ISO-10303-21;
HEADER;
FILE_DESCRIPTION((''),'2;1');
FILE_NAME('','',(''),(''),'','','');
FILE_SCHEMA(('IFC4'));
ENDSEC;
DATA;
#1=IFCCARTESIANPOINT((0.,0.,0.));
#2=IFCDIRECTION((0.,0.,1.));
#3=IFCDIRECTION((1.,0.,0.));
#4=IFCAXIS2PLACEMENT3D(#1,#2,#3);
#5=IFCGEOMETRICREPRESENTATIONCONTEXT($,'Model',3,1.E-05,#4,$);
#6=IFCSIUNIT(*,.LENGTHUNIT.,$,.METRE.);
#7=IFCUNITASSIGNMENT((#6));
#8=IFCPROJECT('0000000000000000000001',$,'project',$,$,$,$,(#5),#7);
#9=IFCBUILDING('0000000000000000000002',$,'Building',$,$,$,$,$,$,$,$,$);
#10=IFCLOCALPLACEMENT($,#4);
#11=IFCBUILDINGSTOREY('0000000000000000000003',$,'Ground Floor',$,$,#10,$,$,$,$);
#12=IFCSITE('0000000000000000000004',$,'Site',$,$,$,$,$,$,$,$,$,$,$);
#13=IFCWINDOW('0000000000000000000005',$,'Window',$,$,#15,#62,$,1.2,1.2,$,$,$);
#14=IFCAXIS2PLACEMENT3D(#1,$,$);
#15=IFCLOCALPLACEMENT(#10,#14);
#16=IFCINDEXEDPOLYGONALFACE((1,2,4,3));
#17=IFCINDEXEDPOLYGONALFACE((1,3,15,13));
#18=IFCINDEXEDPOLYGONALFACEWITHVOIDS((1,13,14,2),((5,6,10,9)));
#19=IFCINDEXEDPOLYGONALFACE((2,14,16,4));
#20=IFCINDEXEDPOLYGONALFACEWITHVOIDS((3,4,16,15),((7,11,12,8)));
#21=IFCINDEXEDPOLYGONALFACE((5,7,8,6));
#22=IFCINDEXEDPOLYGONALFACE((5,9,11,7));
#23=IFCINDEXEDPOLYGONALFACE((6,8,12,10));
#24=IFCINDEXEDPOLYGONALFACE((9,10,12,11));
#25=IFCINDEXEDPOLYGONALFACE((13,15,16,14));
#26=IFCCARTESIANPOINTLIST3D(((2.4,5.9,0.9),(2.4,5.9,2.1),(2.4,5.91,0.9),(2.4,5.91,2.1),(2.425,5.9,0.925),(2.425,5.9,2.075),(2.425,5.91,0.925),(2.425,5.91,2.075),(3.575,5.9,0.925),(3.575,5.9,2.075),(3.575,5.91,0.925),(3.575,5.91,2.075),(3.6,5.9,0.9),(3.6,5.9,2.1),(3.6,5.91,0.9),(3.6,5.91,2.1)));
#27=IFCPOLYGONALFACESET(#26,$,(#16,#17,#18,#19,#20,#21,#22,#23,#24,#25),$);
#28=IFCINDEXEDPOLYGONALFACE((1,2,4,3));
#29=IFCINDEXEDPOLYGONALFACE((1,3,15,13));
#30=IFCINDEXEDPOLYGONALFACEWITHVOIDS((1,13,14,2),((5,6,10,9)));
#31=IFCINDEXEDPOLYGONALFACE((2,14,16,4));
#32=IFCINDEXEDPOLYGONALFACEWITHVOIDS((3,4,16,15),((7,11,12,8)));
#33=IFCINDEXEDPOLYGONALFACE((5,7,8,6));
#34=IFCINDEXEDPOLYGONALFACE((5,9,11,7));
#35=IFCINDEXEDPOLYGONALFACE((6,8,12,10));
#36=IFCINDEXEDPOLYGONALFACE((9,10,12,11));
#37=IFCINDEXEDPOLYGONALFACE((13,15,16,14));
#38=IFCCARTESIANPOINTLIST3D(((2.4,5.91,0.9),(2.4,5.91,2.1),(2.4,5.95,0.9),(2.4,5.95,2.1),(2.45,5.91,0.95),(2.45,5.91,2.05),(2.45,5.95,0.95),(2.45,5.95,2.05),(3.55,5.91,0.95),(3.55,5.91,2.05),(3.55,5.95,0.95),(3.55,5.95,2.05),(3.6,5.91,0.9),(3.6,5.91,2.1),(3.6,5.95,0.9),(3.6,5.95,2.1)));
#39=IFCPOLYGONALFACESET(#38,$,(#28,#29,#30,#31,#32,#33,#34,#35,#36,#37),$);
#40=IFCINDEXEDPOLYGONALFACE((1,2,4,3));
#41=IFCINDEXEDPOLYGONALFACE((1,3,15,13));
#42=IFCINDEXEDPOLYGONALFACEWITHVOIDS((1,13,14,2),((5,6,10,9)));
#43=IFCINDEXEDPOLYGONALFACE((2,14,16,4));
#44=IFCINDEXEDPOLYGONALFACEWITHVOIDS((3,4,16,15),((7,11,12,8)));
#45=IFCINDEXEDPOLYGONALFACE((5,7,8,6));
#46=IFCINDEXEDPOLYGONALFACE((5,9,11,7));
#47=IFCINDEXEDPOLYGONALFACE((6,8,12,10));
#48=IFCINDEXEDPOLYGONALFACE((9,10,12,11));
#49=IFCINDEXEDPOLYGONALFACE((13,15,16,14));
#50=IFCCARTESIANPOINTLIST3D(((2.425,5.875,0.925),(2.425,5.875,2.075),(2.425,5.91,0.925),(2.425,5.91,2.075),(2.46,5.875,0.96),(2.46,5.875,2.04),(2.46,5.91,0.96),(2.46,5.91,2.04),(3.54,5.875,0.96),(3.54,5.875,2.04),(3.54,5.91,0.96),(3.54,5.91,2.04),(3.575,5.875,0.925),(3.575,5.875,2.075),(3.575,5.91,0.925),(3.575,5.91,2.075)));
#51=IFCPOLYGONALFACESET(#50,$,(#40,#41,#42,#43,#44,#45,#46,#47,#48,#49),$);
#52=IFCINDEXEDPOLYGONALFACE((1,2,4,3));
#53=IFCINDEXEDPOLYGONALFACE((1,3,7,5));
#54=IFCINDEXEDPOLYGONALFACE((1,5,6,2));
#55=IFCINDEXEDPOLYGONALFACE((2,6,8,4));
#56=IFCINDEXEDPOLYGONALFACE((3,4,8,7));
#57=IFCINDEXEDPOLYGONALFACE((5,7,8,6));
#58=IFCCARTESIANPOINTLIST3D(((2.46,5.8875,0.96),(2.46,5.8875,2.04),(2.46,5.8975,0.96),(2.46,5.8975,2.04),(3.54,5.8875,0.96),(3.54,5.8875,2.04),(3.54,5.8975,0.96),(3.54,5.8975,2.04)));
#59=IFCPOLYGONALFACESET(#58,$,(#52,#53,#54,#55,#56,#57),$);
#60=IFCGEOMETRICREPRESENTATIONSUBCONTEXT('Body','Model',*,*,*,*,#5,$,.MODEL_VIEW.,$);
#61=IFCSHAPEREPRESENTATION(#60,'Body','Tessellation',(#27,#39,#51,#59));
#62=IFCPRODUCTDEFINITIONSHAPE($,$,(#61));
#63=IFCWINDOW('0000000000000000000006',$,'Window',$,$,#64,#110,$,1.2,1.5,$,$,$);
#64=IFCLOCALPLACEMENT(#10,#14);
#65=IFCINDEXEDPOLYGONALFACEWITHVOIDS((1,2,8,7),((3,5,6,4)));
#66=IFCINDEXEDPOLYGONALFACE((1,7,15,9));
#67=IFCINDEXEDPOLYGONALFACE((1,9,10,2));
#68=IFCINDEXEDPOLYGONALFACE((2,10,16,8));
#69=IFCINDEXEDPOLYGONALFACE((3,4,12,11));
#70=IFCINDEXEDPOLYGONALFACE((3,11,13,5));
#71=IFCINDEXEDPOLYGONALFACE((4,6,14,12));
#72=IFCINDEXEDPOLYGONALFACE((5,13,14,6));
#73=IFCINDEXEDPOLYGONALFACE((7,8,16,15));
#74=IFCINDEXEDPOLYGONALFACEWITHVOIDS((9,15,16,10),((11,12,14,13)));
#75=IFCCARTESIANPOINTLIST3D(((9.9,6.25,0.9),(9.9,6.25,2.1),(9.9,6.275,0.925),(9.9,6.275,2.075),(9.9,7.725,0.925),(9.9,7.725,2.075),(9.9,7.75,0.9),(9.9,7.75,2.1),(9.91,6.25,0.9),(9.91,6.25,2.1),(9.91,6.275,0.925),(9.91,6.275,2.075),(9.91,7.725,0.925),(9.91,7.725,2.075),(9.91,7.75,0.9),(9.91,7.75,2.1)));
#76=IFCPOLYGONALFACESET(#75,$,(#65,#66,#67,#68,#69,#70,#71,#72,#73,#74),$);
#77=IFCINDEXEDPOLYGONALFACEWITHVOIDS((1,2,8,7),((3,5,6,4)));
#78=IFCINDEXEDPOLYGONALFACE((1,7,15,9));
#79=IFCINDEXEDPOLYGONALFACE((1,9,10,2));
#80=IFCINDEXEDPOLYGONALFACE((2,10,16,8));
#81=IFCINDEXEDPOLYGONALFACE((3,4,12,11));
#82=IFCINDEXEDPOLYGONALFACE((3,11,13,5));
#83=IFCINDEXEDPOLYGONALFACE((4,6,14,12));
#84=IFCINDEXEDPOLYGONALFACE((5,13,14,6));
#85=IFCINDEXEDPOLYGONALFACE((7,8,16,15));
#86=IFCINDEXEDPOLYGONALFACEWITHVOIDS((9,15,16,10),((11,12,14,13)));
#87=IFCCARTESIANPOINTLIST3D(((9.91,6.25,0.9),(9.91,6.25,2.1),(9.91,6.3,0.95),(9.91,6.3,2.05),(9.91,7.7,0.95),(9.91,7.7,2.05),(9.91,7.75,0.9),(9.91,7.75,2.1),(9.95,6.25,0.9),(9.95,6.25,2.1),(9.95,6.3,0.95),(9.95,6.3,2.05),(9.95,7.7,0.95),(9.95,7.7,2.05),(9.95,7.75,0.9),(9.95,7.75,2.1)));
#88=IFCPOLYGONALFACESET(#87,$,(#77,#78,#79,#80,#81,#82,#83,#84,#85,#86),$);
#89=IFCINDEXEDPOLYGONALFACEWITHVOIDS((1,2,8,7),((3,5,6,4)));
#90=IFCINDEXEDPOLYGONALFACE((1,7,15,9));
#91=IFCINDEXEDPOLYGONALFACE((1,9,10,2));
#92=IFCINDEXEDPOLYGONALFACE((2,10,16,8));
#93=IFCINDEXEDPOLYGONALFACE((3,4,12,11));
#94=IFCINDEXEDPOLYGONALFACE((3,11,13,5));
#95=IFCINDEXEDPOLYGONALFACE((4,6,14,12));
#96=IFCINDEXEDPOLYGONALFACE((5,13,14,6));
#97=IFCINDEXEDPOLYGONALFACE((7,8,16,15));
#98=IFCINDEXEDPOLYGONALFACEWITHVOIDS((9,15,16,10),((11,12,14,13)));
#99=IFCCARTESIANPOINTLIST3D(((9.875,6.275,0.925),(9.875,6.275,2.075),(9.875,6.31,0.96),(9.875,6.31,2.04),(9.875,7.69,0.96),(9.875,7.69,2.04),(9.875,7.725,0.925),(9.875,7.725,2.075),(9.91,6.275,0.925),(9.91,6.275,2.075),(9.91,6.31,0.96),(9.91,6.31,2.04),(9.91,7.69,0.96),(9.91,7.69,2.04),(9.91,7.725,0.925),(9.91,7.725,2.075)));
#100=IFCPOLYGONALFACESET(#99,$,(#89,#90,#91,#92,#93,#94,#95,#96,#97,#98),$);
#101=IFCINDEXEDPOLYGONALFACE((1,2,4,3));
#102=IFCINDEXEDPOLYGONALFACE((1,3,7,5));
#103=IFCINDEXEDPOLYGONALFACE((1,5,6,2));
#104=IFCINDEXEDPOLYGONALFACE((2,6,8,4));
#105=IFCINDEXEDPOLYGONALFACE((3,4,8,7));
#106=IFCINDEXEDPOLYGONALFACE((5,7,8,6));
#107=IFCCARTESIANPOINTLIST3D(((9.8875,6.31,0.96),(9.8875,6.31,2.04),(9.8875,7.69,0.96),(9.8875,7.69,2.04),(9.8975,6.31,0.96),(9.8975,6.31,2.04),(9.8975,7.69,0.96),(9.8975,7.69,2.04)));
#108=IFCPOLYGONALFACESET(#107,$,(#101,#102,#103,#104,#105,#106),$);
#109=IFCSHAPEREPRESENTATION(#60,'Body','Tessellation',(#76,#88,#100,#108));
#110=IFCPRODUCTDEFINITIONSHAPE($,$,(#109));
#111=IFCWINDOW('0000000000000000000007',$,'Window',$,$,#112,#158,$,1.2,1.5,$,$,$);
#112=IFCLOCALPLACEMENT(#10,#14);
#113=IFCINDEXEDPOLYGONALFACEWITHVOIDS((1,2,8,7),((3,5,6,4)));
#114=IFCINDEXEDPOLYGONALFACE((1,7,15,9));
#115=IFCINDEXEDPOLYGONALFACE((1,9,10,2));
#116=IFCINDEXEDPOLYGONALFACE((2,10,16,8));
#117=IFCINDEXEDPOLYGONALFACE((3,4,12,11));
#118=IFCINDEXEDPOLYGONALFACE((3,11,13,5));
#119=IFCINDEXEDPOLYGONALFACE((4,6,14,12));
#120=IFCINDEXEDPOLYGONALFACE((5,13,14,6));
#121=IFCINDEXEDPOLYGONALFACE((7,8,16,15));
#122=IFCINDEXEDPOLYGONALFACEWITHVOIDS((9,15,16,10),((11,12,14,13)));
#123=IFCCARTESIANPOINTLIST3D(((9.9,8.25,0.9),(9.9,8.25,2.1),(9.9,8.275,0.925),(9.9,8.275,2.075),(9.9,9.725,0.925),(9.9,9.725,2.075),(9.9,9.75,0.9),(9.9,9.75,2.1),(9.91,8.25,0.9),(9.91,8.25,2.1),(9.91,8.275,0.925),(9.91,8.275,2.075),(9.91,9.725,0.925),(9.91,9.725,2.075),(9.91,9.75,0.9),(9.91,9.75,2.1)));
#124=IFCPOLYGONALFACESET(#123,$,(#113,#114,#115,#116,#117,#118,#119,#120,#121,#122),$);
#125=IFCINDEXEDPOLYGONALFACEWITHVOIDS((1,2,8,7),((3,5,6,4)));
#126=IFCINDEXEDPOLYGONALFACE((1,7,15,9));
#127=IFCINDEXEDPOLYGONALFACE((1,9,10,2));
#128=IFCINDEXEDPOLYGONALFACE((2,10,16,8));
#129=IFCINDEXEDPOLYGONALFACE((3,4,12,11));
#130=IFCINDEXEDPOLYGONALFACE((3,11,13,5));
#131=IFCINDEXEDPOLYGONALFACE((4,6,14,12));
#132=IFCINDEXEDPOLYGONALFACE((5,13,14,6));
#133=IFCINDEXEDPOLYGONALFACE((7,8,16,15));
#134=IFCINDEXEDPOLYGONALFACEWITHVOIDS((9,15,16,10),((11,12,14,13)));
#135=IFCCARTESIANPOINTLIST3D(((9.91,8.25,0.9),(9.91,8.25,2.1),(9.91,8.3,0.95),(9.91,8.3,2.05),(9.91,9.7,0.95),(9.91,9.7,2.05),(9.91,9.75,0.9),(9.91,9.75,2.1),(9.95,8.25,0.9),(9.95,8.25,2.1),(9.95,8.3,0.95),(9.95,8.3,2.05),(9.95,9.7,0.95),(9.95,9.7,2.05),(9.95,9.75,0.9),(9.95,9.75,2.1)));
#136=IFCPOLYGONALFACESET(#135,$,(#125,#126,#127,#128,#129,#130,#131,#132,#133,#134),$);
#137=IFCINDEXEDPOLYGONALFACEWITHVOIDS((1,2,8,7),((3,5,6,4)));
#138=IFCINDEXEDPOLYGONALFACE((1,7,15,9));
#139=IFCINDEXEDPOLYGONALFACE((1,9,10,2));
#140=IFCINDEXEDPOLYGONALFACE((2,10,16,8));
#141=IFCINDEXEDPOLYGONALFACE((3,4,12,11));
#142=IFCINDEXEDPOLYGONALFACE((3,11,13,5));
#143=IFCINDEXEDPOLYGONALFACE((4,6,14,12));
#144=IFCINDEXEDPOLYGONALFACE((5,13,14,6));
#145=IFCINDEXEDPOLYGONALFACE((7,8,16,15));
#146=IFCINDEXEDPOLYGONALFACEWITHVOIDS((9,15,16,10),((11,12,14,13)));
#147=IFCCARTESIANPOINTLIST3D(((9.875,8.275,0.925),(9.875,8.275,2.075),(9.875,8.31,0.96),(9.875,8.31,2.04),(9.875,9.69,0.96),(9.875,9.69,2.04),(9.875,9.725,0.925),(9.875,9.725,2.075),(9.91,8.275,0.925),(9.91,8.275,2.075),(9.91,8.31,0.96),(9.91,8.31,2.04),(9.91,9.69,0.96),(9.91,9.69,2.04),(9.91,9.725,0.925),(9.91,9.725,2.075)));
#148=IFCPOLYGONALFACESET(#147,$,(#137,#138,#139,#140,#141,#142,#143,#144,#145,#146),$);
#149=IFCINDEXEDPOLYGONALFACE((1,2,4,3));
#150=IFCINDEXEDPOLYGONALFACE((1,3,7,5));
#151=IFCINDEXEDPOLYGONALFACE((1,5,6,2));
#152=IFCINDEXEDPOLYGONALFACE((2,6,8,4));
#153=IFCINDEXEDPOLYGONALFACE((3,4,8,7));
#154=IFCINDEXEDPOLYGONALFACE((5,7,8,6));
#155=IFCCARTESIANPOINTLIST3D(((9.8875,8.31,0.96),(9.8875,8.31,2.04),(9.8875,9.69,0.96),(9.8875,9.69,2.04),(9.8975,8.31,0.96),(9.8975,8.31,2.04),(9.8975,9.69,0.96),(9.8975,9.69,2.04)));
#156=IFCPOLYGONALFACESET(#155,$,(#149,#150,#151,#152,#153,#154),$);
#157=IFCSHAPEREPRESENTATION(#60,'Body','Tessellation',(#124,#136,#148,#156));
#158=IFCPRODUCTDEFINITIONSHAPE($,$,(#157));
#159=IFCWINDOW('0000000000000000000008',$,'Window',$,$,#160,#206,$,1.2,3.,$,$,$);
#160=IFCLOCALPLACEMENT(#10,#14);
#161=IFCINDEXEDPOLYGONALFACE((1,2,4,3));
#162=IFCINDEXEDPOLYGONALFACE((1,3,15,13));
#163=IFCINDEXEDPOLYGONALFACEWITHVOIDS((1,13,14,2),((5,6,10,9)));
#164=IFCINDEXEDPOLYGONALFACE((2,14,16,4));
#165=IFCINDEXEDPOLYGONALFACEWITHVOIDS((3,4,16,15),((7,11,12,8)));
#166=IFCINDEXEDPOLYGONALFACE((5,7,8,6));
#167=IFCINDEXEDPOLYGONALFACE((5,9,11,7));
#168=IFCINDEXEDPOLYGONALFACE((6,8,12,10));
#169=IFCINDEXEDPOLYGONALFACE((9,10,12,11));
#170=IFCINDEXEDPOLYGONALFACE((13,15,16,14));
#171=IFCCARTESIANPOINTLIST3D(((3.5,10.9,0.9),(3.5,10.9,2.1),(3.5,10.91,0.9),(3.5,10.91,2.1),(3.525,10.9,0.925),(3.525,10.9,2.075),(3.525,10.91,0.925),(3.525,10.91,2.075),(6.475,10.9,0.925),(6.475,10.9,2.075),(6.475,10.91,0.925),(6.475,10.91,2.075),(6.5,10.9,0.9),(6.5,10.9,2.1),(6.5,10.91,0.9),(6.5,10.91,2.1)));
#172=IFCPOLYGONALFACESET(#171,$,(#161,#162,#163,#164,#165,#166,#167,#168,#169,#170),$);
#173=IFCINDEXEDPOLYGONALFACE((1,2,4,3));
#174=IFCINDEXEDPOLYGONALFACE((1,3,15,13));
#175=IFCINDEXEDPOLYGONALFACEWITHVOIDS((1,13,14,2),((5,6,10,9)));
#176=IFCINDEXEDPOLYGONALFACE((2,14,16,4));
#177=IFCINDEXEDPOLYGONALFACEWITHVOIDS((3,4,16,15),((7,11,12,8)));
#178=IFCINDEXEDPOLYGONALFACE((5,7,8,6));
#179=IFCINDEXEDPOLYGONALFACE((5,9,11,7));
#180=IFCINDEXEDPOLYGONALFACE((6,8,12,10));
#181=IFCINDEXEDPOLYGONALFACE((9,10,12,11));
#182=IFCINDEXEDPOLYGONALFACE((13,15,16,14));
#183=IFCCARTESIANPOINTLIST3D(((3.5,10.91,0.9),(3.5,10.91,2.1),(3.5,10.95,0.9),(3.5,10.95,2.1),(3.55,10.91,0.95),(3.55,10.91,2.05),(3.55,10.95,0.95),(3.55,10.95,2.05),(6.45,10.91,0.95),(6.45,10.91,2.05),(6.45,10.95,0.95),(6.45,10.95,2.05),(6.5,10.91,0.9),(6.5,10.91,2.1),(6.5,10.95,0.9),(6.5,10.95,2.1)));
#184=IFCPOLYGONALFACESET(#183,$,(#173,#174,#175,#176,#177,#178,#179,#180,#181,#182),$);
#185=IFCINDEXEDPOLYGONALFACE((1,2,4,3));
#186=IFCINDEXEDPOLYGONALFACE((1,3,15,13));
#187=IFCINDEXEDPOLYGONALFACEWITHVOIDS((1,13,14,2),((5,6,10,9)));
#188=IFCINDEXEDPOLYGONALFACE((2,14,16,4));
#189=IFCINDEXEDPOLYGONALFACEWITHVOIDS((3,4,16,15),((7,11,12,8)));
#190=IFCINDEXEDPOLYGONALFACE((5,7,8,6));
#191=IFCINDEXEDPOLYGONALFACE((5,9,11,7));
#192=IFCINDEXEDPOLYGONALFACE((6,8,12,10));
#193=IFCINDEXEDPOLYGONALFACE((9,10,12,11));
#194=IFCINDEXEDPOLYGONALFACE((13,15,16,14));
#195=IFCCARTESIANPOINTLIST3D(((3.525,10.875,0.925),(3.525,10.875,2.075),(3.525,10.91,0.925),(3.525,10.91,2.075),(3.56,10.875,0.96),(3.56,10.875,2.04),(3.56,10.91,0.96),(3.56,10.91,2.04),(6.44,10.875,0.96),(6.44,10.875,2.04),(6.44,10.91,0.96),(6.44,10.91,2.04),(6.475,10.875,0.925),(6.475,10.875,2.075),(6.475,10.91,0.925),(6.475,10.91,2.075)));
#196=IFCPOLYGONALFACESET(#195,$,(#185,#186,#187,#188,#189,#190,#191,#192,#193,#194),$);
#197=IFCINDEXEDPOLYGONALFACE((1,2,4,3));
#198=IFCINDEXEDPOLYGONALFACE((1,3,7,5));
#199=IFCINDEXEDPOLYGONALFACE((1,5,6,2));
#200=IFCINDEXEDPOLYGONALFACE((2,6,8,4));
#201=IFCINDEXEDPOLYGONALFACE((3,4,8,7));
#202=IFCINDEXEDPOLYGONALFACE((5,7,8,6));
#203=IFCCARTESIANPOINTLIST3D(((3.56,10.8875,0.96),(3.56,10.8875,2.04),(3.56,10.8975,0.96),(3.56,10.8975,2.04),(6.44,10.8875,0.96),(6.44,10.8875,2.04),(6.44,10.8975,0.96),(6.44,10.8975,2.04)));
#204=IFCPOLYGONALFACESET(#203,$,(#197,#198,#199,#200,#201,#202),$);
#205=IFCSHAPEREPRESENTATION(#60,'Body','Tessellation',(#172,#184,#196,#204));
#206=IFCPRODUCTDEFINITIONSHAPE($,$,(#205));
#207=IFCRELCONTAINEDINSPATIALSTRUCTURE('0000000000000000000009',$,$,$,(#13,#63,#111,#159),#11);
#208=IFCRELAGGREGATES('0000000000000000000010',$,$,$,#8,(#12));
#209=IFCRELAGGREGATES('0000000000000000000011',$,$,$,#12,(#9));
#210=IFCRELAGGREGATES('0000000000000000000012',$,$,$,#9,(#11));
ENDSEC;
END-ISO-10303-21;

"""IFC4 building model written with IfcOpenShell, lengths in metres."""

from ifc_helpers import new_model, si_unit, frame, origin_with_axes, place, context, subcontext, project, spatial, line, indexed_curve, outline, extrude, element, save


model = new_model("IFC4")

# Units and contexts
model_context = context("Model", 3, precision=1e-05, world=origin_with_axes())
body_context = subcontext(model_context, "Body", "Model", "MODEL_VIEW")
ifc_project = project(units=[si_unit("LENGTHUNIT", "METRE")], contexts=[model_context])

# Site, building, storey
site = spatial("IfcSite", under=ifc_project, Name="Site")
building = spatial("IfcBuilding", under=site, Name="Building")
storey_placement = place(None, origin_with_axes())
storey = spatial("IfcBuildingStorey", under=building, at=storey_placement, Name="Ground Floor")

# Windows
window_1_placement = place(storey_placement, frame((3.6, 6.0, 0.9), z_axis=(0.0, 0.0, 1.0), x_axis=(-1.0, 0.0, 0.0)))
element("IfcWindow", 1, at=window_1_placement, inside=storey, Name="Window", OverallHeight=1.2, OverallWidth=1.2, context=body_context, shape_type="SweptSolid", body=[
    extrude(outline(indexed_curve([(0.0, 0.0), (1.2, 0.0), (1.2, 1.2), (0.0, 1.2)], segments=[line(1, 2, 3, 4, 1)]), holes=[indexed_curve([(0.025, 0.025), (1.175, 0.025), (1.175, 1.175), (0.025, 1.175)], segments=[line(1, 2, 3, 4, 1)])]), frame((0.0, 0.09, 0.0), z_axis=(0.0, -1.0, 0.0), x_axis=(1.0, 0.0, 0.0)), (0.0, 0.0, -1.0), 0.01),
    extrude(outline(indexed_curve([(0.0, 0.0), (1.2, 0.0), (1.2, 1.2), (0.0, 1.2)], segments=[line(1, 2, 3, 4, 1)]), holes=[indexed_curve([(0.05, 0.05), (1.15, 0.05), (1.15, 1.15), (0.05, 1.15)], segments=[line(1, 2, 3, 4, 1)])]), frame((0.0, 0.05, 0.0), z_axis=(0.0, -1.0, 0.0), x_axis=(1.0, 0.0, 0.0)), (0.0, 0.0, -1.0), 0.04),
    extrude(outline(indexed_curve([(0.0, 0.0), (1.15, 0.0), (1.15, 1.15), (0.0, 1.15)], segments=[line(1, 2, 3, 4, 1)]), holes=[indexed_curve([(0.035, 0.035), (1.115, 0.035), (1.115, 1.115), (0.035, 1.115)], segments=[line(1, 2, 3, 4, 1)])]), frame((0.025, 0.09, 0.025), z_axis=(0.0, -1.0, 0.0), x_axis=(1.0, 0.0, 0.0)), (0.0, 0.0, -1.0), 0.035),
    extrude(outline(indexed_curve([(0.035, 0.035), (1.115, 0.035), (1.115, 1.115), (0.035, 1.115)], segments=[line(1, 2, 3, 4, 1)])), frame((0.025, 0.1025, 0.025), z_axis=(0.0, -1.0, 0.0), x_axis=(1.0, 0.0, 0.0)), (0.0, 0.0, -1.0), 0.01),
])
for number, where, z_axis, x_axis, name in (
    (2, (10.0, 6.25, 0.9), (0.0, 0.0, 1.0), (0.0, 1.0, 0.0), "Window"),
    (3, (10.0, 8.25, 0.9), (0.0, 0.0, 1.0), (0.0, 1.0, 0.0), "Window"),
):
    element("IfcWindow", number, at=place(storey_placement, frame(where, z_axis=z_axis, x_axis=x_axis)), inside=storey, Name=name, OverallHeight=1.2, OverallWidth=1.5, context=body_context, shape_type="SweptSolid", body=[
        extrude(outline(indexed_curve([(0.0, 0.0), (1.5, 0.0), (1.5, 1.2), (0.0, 1.2)], segments=[line(1, 2, 3, 4, 1)]), holes=[indexed_curve([(0.025, 0.025), (1.475, 0.025), (1.475, 1.175), (0.025, 1.175)], segments=[line(1, 2, 3, 4, 1)])]), frame((0.0, 0.09, 0.0), z_axis=(0.0, -1.0, 0.0), x_axis=(1.0, 0.0, 0.0)), (0.0, 0.0, -1.0), 0.01),
        extrude(outline(indexed_curve([(0.0, 0.0), (1.5, 0.0), (1.5, 1.2), (0.0, 1.2)], segments=[line(1, 2, 3, 4, 1)]), holes=[indexed_curve([(0.05, 0.05), (1.45, 0.05), (1.45, 1.15), (0.05, 1.15)], segments=[line(1, 2, 3, 4, 1)])]), frame((0.0, 0.05, 0.0), z_axis=(0.0, -1.0, 0.0), x_axis=(1.0, 0.0, 0.0)), (0.0, 0.0, -1.0), 0.04),
        extrude(outline(indexed_curve([(0.0, 0.0), (1.45, 0.0), (1.45, 1.15), (0.0, 1.15)], segments=[line(1, 2, 3, 4, 1)]), holes=[indexed_curve([(0.035, 0.035), (1.415, 0.035), (1.415, 1.115), (0.035, 1.115)], segments=[line(1, 2, 3, 4, 1)])]), frame((0.025, 0.09, 0.025), z_axis=(0.0, -1.0, 0.0), x_axis=(1.0, 0.0, 0.0)), (0.0, 0.0, -1.0), 0.035),
        extrude(outline(indexed_curve([(0.035, 0.035), (1.415, 0.035), (1.415, 1.115), (0.035, 1.115)], segments=[line(1, 2, 3, 4, 1)])), frame((0.025, 0.1025, 0.025), z_axis=(0.0, -1.0, 0.0), x_axis=(1.0, 0.0, 0.0)), (0.0, 0.0, -1.0), 0.01),
    ])
window_2_placement = place(storey_placement, frame((6.5, 11.0, 0.9), z_axis=(0.0, 0.0, 1.0), x_axis=(-1.0, 0.0, 0.0)))
element("IfcWindow", 4, at=window_2_placement, inside=storey, Name="Window", OverallHeight=1.2, OverallWidth=3.0, context=body_context, shape_type="SweptSolid", body=[
    extrude(outline(indexed_curve([(0.0, 0.0), (3.0, 0.0), (3.0, 1.2), (0.0, 1.2)], segments=[line(1, 2, 3, 4, 1)]), holes=[indexed_curve([(0.025, 0.025), (2.975, 0.025), (2.975, 1.175), (0.025, 1.175)], segments=[line(1, 2, 3, 4, 1)])]), frame((0.0, 0.09, 0.0), z_axis=(0.0, -1.0, 0.0), x_axis=(1.0, 0.0, 0.0)), (0.0, 0.0, -1.0), 0.01),
    extrude(outline(indexed_curve([(0.0, 0.0), (3.0, 0.0), (3.0, 1.2), (0.0, 1.2)], segments=[line(1, 2, 3, 4, 1)]), holes=[indexed_curve([(0.05, 0.05), (2.95, 0.05), (2.95, 1.15), (0.05, 1.15)], segments=[line(1, 2, 3, 4, 1)])]), frame((0.0, 0.05, 0.0), z_axis=(0.0, -1.0, 0.0), x_axis=(1.0, 0.0, 0.0)), (0.0, 0.0, -1.0), 0.04),
    extrude(outline(indexed_curve([(0.0, 0.0), (2.95, 0.0), (2.95, 1.15), (0.0, 1.15)], segments=[line(1, 2, 3, 4, 1)]), holes=[indexed_curve([(0.035, 0.035), (2.915, 0.035), (2.915, 1.115), (0.035, 1.115)], segments=[line(1, 2, 3, 4, 1)])]), frame((0.025, 0.09, 0.025), z_axis=(0.0, -1.0, 0.0), x_axis=(1.0, 0.0, 0.0)), (0.0, 0.0, -1.0), 0.035),
    extrude(outline(indexed_curve([(0.035, 0.035), (2.915, 0.035), (2.915, 1.115), (0.035, 1.115)], segments=[line(1, 2, 3, 4, 1)])), frame((0.025, 0.1025, 0.025), z_axis=(0.0, -1.0, 0.0), x_axis=(1.0, 0.0, 0.0)), (0.0, 0.0, -1.0), 0.01),
])

save(model, "model.ifc")
